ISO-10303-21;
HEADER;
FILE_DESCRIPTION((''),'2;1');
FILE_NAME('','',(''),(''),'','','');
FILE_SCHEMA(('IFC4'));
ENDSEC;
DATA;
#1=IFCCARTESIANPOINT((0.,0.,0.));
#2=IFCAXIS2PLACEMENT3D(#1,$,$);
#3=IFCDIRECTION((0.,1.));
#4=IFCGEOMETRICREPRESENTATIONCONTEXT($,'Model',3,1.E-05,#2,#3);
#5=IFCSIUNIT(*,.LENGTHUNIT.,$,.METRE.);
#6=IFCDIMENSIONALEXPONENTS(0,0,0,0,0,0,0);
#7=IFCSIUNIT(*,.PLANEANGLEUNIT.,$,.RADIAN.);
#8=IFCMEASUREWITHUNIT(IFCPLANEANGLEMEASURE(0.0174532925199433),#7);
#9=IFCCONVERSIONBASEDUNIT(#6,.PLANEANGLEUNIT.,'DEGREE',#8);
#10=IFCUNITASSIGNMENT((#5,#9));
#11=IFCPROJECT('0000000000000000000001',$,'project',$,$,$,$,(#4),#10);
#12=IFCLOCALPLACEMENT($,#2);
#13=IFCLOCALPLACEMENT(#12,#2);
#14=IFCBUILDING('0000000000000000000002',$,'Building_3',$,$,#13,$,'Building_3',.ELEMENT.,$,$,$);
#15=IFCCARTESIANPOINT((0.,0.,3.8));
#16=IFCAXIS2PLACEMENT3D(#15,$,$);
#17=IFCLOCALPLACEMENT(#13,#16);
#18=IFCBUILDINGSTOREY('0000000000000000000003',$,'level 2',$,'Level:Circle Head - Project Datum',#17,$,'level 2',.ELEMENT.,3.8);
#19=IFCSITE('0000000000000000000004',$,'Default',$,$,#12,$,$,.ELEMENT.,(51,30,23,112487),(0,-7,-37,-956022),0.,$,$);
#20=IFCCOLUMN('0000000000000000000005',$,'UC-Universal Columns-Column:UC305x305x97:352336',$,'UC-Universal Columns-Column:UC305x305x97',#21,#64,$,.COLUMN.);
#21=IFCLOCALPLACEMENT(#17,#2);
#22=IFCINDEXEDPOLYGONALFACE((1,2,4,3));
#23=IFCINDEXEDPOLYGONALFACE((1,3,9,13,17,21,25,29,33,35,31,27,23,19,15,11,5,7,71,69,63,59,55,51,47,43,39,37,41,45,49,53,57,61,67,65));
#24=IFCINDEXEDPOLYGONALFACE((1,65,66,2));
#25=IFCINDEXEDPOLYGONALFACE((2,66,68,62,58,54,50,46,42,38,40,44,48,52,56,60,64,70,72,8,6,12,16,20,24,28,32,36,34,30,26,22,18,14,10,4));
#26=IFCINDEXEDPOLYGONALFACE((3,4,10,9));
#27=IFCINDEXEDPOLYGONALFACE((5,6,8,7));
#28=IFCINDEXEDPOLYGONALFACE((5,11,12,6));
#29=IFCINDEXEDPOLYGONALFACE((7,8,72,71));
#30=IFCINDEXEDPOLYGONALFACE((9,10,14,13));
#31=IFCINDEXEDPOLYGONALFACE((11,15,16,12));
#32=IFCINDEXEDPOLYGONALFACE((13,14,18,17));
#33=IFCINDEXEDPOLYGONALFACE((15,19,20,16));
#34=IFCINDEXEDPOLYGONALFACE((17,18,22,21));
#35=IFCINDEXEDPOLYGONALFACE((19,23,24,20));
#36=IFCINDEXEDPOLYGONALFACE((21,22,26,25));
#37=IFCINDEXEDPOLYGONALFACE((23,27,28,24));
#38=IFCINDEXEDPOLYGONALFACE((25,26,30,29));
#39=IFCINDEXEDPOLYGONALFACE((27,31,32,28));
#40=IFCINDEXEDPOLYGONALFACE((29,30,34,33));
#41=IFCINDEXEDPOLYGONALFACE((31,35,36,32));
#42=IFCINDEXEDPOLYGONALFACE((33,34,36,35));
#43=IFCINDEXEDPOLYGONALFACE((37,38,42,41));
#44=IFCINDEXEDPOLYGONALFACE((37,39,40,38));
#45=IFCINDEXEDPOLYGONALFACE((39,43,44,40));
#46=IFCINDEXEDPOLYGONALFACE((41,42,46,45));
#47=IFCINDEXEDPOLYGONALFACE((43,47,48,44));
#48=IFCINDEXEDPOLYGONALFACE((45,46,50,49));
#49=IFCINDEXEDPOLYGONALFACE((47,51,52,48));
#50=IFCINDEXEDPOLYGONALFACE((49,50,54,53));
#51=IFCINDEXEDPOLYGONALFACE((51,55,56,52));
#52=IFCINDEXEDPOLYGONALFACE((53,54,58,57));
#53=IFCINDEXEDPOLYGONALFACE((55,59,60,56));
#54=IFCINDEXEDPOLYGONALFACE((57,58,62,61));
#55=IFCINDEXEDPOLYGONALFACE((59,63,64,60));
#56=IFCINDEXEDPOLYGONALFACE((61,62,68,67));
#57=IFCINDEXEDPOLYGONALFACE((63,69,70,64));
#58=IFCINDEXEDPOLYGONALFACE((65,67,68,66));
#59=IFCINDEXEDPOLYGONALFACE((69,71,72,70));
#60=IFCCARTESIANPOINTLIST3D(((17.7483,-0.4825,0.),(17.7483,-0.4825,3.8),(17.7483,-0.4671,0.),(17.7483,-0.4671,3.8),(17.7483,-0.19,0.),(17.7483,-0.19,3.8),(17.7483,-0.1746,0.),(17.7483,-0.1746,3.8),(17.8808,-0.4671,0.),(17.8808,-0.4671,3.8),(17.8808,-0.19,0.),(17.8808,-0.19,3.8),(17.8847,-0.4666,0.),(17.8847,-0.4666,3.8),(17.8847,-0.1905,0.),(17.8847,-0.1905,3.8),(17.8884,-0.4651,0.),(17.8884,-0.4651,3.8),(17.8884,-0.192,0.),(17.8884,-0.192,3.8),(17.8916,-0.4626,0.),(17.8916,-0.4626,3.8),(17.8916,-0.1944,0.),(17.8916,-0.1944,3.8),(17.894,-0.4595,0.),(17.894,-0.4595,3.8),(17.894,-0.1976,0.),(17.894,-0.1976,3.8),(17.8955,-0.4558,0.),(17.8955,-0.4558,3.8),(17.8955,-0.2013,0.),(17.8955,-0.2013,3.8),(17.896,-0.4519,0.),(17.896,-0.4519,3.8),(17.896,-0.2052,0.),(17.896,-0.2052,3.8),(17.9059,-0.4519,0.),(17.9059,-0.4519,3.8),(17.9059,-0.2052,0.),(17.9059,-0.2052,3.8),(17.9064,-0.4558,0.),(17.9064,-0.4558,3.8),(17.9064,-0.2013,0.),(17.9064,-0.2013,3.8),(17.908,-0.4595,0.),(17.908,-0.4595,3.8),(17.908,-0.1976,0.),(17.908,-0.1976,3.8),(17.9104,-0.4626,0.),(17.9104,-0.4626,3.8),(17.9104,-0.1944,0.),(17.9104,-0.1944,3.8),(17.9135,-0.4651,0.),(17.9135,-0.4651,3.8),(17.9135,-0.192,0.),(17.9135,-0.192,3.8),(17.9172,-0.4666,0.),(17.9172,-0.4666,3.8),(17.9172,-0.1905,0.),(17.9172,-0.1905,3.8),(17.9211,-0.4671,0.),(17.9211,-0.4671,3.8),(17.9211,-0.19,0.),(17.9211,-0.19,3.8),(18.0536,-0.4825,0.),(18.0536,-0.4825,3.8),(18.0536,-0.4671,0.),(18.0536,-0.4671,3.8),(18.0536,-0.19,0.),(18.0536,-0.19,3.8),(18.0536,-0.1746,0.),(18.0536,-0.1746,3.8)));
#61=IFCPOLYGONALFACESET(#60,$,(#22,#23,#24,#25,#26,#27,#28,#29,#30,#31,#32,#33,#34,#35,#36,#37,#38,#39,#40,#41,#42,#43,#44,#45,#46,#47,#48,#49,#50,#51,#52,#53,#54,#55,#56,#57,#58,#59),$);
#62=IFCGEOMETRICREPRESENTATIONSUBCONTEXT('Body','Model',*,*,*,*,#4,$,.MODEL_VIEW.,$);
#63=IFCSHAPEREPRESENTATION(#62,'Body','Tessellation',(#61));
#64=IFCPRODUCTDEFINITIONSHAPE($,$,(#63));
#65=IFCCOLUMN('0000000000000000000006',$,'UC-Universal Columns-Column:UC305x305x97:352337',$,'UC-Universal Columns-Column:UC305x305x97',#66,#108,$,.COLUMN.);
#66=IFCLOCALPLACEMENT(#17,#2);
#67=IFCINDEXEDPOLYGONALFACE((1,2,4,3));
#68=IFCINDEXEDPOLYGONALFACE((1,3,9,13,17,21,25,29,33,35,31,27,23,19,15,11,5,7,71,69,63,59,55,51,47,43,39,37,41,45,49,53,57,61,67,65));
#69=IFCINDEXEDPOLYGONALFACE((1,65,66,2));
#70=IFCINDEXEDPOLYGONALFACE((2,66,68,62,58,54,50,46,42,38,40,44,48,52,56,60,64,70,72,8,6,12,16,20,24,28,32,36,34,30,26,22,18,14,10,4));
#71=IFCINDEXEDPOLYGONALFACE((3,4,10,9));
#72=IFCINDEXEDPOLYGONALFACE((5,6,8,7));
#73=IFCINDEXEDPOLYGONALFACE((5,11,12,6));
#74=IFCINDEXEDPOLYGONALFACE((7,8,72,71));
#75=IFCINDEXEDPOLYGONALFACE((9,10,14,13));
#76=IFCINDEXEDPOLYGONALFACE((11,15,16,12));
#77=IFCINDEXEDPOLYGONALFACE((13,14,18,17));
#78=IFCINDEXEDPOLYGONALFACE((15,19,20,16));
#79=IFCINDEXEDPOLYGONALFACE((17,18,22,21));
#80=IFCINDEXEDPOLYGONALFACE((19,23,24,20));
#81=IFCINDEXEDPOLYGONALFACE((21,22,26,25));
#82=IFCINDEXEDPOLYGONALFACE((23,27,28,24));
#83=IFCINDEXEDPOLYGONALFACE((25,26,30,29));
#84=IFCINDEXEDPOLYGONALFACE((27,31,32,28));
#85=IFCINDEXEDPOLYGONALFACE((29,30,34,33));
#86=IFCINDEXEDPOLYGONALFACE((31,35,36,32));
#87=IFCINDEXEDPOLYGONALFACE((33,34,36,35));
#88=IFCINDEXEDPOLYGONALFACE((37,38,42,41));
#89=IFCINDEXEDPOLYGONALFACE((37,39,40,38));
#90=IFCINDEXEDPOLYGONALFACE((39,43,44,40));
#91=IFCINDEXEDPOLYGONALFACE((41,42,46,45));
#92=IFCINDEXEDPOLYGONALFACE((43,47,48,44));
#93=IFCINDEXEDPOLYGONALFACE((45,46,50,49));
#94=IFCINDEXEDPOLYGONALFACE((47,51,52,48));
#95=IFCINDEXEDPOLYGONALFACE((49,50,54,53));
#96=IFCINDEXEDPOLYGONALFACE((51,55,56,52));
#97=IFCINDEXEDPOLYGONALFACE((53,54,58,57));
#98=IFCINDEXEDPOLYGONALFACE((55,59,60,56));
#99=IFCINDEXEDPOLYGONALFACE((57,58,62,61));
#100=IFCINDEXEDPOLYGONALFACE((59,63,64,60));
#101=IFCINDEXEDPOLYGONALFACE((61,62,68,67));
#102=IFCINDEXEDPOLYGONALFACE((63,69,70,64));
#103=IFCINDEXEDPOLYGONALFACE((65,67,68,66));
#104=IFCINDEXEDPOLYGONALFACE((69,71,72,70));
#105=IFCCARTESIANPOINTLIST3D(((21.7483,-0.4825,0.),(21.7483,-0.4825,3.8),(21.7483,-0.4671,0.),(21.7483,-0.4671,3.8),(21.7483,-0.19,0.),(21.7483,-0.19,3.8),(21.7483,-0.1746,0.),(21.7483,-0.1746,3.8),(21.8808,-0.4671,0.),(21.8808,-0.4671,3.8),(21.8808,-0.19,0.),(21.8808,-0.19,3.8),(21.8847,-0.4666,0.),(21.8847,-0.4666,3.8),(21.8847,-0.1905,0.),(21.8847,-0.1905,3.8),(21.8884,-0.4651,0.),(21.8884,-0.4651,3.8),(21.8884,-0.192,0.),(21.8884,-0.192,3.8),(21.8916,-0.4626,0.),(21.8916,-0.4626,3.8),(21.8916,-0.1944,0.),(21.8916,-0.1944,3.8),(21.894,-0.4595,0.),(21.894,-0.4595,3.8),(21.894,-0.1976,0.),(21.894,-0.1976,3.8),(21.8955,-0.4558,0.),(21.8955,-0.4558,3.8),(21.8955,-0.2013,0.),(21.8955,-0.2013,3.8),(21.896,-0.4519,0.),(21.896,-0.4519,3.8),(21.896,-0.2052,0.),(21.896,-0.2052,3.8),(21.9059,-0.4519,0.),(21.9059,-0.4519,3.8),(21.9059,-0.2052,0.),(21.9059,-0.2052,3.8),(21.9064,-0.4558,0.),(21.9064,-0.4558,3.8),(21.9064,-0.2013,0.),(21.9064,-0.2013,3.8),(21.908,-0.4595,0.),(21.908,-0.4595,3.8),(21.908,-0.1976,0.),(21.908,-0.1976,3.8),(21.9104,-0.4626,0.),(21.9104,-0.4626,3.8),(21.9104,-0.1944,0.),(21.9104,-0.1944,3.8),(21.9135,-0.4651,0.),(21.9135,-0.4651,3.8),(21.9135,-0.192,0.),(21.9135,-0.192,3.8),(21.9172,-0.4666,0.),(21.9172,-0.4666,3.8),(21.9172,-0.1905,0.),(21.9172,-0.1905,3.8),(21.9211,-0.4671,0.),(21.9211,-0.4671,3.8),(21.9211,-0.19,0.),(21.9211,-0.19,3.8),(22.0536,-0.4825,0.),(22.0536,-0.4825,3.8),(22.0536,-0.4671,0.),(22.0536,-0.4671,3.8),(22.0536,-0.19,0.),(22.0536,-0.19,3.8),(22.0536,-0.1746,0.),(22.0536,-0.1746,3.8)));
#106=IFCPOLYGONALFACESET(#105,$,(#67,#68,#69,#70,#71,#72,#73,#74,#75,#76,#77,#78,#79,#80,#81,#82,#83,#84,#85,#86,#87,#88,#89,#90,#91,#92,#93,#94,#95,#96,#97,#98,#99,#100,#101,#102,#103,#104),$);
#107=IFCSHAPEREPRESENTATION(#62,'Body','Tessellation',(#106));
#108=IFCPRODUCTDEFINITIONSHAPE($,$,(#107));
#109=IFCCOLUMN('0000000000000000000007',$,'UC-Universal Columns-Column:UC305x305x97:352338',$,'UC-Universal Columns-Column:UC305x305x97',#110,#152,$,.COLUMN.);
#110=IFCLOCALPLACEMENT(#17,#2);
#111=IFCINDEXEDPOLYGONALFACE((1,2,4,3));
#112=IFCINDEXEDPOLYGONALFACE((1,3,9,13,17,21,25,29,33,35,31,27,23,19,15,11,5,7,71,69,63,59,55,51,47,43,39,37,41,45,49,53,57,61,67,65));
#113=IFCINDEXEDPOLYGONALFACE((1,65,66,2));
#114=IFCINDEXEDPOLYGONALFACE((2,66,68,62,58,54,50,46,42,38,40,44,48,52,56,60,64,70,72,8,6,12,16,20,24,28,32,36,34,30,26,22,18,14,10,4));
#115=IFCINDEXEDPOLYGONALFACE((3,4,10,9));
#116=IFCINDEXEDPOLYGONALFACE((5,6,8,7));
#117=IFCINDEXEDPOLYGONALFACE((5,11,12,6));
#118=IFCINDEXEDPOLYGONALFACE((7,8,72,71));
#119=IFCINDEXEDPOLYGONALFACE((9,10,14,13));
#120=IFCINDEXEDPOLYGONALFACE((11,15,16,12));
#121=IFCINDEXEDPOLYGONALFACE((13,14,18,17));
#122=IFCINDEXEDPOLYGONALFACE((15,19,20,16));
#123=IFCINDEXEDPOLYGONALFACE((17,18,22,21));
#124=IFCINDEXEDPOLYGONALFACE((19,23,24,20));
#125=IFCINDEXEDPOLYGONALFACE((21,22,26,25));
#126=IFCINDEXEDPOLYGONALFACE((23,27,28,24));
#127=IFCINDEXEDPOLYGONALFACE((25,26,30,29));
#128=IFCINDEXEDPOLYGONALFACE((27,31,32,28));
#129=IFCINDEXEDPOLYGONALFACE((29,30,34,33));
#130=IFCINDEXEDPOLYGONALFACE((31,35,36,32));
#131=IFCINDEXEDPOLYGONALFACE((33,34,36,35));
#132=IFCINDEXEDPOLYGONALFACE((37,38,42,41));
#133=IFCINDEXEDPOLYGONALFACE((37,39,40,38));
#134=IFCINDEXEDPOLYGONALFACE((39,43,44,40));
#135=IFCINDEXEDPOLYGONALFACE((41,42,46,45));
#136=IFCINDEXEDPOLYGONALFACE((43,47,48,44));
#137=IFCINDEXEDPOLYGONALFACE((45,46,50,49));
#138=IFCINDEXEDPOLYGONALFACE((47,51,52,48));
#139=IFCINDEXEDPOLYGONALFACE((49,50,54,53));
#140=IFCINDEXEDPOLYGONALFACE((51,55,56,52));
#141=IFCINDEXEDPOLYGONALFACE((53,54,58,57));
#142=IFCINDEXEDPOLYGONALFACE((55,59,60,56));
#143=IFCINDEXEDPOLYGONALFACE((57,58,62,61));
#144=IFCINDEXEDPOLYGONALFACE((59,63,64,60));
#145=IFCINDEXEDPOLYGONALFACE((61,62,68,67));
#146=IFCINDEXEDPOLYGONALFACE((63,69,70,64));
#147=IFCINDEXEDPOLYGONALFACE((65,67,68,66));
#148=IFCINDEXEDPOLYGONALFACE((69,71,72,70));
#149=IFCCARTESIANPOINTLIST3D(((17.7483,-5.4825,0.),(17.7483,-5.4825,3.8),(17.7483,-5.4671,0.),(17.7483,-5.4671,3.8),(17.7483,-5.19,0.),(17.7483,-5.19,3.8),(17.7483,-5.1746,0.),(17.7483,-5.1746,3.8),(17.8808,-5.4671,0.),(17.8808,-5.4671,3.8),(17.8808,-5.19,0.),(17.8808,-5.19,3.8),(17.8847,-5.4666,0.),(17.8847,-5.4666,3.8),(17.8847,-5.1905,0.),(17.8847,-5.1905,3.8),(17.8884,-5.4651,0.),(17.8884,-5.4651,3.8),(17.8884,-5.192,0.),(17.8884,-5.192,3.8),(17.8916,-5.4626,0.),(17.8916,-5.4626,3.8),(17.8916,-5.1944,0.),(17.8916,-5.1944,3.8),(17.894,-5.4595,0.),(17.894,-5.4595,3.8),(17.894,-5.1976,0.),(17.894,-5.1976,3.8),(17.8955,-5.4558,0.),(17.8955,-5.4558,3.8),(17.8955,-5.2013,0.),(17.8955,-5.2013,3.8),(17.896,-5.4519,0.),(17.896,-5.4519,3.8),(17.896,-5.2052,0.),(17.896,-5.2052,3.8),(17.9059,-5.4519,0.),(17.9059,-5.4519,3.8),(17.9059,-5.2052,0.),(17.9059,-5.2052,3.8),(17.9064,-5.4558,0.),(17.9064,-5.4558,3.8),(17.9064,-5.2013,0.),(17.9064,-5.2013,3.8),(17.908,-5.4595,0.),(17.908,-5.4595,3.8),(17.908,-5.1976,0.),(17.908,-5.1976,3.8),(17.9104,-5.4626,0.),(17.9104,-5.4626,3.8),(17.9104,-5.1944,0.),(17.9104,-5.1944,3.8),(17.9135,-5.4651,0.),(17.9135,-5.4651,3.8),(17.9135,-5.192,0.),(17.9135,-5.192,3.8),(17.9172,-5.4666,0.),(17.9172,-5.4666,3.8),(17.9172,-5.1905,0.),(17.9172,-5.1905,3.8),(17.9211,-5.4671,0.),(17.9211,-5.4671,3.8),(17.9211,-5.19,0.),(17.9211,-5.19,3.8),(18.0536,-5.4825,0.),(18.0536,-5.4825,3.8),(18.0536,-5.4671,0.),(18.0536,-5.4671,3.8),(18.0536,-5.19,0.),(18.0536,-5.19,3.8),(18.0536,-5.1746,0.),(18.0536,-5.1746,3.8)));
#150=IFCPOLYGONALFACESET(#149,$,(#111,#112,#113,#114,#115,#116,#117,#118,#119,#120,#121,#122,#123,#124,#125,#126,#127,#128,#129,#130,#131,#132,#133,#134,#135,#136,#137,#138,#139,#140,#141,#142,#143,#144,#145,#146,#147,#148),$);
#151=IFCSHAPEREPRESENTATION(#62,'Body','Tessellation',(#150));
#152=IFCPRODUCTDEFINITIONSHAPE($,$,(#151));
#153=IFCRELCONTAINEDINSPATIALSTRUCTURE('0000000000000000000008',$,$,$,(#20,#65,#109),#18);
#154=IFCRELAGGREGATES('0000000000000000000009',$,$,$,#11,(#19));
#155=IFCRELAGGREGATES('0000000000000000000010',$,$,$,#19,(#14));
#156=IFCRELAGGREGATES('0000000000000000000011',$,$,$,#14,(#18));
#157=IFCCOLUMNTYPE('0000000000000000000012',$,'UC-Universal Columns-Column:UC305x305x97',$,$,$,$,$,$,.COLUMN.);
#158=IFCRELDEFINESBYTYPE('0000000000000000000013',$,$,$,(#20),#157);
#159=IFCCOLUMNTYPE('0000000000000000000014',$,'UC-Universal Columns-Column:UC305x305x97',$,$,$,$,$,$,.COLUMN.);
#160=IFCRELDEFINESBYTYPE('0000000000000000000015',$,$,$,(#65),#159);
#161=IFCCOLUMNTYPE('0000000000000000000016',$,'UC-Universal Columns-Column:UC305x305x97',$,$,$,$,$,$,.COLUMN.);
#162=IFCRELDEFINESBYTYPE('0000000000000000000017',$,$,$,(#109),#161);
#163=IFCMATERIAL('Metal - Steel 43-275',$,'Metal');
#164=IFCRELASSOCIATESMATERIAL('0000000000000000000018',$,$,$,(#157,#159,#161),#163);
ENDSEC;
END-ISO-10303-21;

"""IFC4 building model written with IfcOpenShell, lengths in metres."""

from ifc_helpers import new_model, entity, si_unit, converted_unit, direction, frame, frame_2d, origin, place, context, subcontext, project, spatial, i_section, extrude, source, transform, mapped, material, material_profile, profile_set, type_object, type_shapes, element, save


model = new_model("IFC4")

# Units and contexts
model_context = context("Model", 3, precision=1e-05, world=origin(), true_north=direction((0.0, 1.0)))
body_context = subcontext(model_context, "Body", "Model", "MODEL_VIEW")
ifc_project = project(units=[si_unit("LENGTHUNIT", "METRE"), converted_unit("PLANEANGLEUNIT", "DEGREE", entity("IfcPlaneAngleMeasure", 0.0174532925199433), si_unit("PLANEANGLEUNIT", "RADIAN"), dimensions=[0, 0, 0, 0, 0, 0, 0])], contexts=[model_context])

# Site, building, storey
site_placement = place(None, origin())
site = spatial("IfcSite", under=ifc_project, at=site_placement, Name="Default", CompositionType="ELEMENT", RefLatitude=(51, 30, 23, 112487), RefLongitude=(0, -7, -37, -956022), RefElevation=0.0)
building_placement = place(site_placement, origin())
building = spatial("IfcBuilding", under=site, at=building_placement, Name="Building_3", LongName="Building_3", CompositionType="ELEMENT")
storey_placement = place(building_placement, frame((0.0, 0.0, 3.8)))
storey = spatial("IfcBuildingStorey", under=building, at=storey_placement, Name="level 2", ObjectType="Level:Circle Head - Project Datum", LongName="level 2", CompositionType="ELEMENT", Elevation=3.8)

# Columns
ifc_material_1 = material(Name="Metal - Steel 43-275", Category="Metal")
ifc_material_profile_1 = material_profile(ifc_material_1, i_section(OverallWidth=0.3053, OverallDepth=0.3079, WebThickness=0.0099, FlangeThickness=0.0154, FilletRadius=0.0152, at=frame_2d((0.0, 0.0), x_axis=(1.0, 0.0))), Name="UC305x305x97")
ifc_profile_set_1 = profile_set([ifc_material_profile_1], Name="UC305x305x97")
column_type_1 = type_object("IfcColumnType", Name="UC-Universal Columns-Column:UC305x305x97", PredefinedType="COLUMN", material=ifc_profile_set_1)
shared_shape_1 = source(origin(), body_context, "Body", "SweptSolid", [
    extrude(i_section(OverallWidth=0.3053, OverallDepth=0.3079, WebThickness=0.0099, FlangeThickness=0.0154, FilletRadius=0.0152, at=frame_2d((0.0, 0.0), x_axis=(1.0, 0.0))), frame((17.901, -0.3285, 3.8), z_axis=(0.0, 0.0, 1.0), x_axis=(-1.0, 0.0, 0.0)), (0.0, 0.0, 1.0), 3.8),
])
type_shapes(column_type_1, [shared_shape_1])
column_1_placement = place(storey_placement, frame((0.0, 0.0, -3.8)))
element("IfcColumn", 1, at=column_1_placement, inside=storey, type_object=column_type_1, Name="UC-Universal Columns-Column:UC305x305x97:352336", ObjectType="UC-Universal Columns-Column:UC305x305x97", PredefinedType="COLUMN", context=body_context, shape_type="MappedRepresentation", body=[
    mapped(shared_shape_1, transform((0.0, 0.0, 0.0), scale=1.0)),
])
column_type_2 = type_object("IfcColumnType", Name="UC-Universal Columns-Column:UC305x305x97", PredefinedType="COLUMN", material=ifc_profile_set_1)
shared_shape_2 = source(origin(), body_context, "Body", "SweptSolid", [
    extrude(i_section(OverallWidth=0.3053, OverallDepth=0.3079, WebThickness=0.0099, FlangeThickness=0.0154, FilletRadius=0.0152, at=frame_2d((0.0, 0.0), x_axis=(1.0, 0.0))), frame((21.901, -0.3285, 3.8), z_axis=(0.0, 0.0, 1.0), x_axis=(-1.0, 0.0, 0.0)), (0.0, 0.0, 1.0), 3.8),
])
type_shapes(column_type_2, [shared_shape_2])
column_2_placement = place(storey_placement, frame((0.0, 0.0, -3.8)))
element("IfcColumn", 2, at=column_2_placement, inside=storey, type_object=column_type_2, Name="UC-Universal Columns-Column:UC305x305x97:352337", ObjectType="UC-Universal Columns-Column:UC305x305x97", PredefinedType="COLUMN", context=body_context, shape_type="MappedRepresentation", body=[
    mapped(shared_shape_2, transform((0.0, 0.0, 0.0), scale=1.0)),
])
column_type_3 = type_object("IfcColumnType", Name="UC-Universal Columns-Column:UC305x305x97", PredefinedType="COLUMN", material=ifc_profile_set_1)
shared_shape_3 = source(origin(), body_context, "Body", "SweptSolid", [
    extrude(i_section(OverallWidth=0.3053, OverallDepth=0.3079, WebThickness=0.0099, FlangeThickness=0.0154, FilletRadius=0.0152, at=frame_2d((0.0, 0.0), x_axis=(1.0, 0.0))), frame((17.901, -5.3285, 3.8), z_axis=(0.0, 0.0, 1.0), x_axis=(-1.0, 0.0, 0.0)), (0.0, 0.0, 1.0), 3.8),
])
type_shapes(column_type_3, [shared_shape_3])
column_3_placement = place(storey_placement, frame((0.0, 0.0, -3.8)))
element("IfcColumn", 3, at=column_3_placement, inside=storey, type_object=column_type_3, Name="UC-Universal Columns-Column:UC305x305x97:352338", ObjectType="UC-Universal Columns-Column:UC305x305x97", PredefinedType="COLUMN", context=body_context, shape_type="MappedRepresentation", body=[
    mapped(shared_shape_3, transform((0.0, 0.0, 0.0), scale=1.0)),
])

save(model, "model.ifc")
